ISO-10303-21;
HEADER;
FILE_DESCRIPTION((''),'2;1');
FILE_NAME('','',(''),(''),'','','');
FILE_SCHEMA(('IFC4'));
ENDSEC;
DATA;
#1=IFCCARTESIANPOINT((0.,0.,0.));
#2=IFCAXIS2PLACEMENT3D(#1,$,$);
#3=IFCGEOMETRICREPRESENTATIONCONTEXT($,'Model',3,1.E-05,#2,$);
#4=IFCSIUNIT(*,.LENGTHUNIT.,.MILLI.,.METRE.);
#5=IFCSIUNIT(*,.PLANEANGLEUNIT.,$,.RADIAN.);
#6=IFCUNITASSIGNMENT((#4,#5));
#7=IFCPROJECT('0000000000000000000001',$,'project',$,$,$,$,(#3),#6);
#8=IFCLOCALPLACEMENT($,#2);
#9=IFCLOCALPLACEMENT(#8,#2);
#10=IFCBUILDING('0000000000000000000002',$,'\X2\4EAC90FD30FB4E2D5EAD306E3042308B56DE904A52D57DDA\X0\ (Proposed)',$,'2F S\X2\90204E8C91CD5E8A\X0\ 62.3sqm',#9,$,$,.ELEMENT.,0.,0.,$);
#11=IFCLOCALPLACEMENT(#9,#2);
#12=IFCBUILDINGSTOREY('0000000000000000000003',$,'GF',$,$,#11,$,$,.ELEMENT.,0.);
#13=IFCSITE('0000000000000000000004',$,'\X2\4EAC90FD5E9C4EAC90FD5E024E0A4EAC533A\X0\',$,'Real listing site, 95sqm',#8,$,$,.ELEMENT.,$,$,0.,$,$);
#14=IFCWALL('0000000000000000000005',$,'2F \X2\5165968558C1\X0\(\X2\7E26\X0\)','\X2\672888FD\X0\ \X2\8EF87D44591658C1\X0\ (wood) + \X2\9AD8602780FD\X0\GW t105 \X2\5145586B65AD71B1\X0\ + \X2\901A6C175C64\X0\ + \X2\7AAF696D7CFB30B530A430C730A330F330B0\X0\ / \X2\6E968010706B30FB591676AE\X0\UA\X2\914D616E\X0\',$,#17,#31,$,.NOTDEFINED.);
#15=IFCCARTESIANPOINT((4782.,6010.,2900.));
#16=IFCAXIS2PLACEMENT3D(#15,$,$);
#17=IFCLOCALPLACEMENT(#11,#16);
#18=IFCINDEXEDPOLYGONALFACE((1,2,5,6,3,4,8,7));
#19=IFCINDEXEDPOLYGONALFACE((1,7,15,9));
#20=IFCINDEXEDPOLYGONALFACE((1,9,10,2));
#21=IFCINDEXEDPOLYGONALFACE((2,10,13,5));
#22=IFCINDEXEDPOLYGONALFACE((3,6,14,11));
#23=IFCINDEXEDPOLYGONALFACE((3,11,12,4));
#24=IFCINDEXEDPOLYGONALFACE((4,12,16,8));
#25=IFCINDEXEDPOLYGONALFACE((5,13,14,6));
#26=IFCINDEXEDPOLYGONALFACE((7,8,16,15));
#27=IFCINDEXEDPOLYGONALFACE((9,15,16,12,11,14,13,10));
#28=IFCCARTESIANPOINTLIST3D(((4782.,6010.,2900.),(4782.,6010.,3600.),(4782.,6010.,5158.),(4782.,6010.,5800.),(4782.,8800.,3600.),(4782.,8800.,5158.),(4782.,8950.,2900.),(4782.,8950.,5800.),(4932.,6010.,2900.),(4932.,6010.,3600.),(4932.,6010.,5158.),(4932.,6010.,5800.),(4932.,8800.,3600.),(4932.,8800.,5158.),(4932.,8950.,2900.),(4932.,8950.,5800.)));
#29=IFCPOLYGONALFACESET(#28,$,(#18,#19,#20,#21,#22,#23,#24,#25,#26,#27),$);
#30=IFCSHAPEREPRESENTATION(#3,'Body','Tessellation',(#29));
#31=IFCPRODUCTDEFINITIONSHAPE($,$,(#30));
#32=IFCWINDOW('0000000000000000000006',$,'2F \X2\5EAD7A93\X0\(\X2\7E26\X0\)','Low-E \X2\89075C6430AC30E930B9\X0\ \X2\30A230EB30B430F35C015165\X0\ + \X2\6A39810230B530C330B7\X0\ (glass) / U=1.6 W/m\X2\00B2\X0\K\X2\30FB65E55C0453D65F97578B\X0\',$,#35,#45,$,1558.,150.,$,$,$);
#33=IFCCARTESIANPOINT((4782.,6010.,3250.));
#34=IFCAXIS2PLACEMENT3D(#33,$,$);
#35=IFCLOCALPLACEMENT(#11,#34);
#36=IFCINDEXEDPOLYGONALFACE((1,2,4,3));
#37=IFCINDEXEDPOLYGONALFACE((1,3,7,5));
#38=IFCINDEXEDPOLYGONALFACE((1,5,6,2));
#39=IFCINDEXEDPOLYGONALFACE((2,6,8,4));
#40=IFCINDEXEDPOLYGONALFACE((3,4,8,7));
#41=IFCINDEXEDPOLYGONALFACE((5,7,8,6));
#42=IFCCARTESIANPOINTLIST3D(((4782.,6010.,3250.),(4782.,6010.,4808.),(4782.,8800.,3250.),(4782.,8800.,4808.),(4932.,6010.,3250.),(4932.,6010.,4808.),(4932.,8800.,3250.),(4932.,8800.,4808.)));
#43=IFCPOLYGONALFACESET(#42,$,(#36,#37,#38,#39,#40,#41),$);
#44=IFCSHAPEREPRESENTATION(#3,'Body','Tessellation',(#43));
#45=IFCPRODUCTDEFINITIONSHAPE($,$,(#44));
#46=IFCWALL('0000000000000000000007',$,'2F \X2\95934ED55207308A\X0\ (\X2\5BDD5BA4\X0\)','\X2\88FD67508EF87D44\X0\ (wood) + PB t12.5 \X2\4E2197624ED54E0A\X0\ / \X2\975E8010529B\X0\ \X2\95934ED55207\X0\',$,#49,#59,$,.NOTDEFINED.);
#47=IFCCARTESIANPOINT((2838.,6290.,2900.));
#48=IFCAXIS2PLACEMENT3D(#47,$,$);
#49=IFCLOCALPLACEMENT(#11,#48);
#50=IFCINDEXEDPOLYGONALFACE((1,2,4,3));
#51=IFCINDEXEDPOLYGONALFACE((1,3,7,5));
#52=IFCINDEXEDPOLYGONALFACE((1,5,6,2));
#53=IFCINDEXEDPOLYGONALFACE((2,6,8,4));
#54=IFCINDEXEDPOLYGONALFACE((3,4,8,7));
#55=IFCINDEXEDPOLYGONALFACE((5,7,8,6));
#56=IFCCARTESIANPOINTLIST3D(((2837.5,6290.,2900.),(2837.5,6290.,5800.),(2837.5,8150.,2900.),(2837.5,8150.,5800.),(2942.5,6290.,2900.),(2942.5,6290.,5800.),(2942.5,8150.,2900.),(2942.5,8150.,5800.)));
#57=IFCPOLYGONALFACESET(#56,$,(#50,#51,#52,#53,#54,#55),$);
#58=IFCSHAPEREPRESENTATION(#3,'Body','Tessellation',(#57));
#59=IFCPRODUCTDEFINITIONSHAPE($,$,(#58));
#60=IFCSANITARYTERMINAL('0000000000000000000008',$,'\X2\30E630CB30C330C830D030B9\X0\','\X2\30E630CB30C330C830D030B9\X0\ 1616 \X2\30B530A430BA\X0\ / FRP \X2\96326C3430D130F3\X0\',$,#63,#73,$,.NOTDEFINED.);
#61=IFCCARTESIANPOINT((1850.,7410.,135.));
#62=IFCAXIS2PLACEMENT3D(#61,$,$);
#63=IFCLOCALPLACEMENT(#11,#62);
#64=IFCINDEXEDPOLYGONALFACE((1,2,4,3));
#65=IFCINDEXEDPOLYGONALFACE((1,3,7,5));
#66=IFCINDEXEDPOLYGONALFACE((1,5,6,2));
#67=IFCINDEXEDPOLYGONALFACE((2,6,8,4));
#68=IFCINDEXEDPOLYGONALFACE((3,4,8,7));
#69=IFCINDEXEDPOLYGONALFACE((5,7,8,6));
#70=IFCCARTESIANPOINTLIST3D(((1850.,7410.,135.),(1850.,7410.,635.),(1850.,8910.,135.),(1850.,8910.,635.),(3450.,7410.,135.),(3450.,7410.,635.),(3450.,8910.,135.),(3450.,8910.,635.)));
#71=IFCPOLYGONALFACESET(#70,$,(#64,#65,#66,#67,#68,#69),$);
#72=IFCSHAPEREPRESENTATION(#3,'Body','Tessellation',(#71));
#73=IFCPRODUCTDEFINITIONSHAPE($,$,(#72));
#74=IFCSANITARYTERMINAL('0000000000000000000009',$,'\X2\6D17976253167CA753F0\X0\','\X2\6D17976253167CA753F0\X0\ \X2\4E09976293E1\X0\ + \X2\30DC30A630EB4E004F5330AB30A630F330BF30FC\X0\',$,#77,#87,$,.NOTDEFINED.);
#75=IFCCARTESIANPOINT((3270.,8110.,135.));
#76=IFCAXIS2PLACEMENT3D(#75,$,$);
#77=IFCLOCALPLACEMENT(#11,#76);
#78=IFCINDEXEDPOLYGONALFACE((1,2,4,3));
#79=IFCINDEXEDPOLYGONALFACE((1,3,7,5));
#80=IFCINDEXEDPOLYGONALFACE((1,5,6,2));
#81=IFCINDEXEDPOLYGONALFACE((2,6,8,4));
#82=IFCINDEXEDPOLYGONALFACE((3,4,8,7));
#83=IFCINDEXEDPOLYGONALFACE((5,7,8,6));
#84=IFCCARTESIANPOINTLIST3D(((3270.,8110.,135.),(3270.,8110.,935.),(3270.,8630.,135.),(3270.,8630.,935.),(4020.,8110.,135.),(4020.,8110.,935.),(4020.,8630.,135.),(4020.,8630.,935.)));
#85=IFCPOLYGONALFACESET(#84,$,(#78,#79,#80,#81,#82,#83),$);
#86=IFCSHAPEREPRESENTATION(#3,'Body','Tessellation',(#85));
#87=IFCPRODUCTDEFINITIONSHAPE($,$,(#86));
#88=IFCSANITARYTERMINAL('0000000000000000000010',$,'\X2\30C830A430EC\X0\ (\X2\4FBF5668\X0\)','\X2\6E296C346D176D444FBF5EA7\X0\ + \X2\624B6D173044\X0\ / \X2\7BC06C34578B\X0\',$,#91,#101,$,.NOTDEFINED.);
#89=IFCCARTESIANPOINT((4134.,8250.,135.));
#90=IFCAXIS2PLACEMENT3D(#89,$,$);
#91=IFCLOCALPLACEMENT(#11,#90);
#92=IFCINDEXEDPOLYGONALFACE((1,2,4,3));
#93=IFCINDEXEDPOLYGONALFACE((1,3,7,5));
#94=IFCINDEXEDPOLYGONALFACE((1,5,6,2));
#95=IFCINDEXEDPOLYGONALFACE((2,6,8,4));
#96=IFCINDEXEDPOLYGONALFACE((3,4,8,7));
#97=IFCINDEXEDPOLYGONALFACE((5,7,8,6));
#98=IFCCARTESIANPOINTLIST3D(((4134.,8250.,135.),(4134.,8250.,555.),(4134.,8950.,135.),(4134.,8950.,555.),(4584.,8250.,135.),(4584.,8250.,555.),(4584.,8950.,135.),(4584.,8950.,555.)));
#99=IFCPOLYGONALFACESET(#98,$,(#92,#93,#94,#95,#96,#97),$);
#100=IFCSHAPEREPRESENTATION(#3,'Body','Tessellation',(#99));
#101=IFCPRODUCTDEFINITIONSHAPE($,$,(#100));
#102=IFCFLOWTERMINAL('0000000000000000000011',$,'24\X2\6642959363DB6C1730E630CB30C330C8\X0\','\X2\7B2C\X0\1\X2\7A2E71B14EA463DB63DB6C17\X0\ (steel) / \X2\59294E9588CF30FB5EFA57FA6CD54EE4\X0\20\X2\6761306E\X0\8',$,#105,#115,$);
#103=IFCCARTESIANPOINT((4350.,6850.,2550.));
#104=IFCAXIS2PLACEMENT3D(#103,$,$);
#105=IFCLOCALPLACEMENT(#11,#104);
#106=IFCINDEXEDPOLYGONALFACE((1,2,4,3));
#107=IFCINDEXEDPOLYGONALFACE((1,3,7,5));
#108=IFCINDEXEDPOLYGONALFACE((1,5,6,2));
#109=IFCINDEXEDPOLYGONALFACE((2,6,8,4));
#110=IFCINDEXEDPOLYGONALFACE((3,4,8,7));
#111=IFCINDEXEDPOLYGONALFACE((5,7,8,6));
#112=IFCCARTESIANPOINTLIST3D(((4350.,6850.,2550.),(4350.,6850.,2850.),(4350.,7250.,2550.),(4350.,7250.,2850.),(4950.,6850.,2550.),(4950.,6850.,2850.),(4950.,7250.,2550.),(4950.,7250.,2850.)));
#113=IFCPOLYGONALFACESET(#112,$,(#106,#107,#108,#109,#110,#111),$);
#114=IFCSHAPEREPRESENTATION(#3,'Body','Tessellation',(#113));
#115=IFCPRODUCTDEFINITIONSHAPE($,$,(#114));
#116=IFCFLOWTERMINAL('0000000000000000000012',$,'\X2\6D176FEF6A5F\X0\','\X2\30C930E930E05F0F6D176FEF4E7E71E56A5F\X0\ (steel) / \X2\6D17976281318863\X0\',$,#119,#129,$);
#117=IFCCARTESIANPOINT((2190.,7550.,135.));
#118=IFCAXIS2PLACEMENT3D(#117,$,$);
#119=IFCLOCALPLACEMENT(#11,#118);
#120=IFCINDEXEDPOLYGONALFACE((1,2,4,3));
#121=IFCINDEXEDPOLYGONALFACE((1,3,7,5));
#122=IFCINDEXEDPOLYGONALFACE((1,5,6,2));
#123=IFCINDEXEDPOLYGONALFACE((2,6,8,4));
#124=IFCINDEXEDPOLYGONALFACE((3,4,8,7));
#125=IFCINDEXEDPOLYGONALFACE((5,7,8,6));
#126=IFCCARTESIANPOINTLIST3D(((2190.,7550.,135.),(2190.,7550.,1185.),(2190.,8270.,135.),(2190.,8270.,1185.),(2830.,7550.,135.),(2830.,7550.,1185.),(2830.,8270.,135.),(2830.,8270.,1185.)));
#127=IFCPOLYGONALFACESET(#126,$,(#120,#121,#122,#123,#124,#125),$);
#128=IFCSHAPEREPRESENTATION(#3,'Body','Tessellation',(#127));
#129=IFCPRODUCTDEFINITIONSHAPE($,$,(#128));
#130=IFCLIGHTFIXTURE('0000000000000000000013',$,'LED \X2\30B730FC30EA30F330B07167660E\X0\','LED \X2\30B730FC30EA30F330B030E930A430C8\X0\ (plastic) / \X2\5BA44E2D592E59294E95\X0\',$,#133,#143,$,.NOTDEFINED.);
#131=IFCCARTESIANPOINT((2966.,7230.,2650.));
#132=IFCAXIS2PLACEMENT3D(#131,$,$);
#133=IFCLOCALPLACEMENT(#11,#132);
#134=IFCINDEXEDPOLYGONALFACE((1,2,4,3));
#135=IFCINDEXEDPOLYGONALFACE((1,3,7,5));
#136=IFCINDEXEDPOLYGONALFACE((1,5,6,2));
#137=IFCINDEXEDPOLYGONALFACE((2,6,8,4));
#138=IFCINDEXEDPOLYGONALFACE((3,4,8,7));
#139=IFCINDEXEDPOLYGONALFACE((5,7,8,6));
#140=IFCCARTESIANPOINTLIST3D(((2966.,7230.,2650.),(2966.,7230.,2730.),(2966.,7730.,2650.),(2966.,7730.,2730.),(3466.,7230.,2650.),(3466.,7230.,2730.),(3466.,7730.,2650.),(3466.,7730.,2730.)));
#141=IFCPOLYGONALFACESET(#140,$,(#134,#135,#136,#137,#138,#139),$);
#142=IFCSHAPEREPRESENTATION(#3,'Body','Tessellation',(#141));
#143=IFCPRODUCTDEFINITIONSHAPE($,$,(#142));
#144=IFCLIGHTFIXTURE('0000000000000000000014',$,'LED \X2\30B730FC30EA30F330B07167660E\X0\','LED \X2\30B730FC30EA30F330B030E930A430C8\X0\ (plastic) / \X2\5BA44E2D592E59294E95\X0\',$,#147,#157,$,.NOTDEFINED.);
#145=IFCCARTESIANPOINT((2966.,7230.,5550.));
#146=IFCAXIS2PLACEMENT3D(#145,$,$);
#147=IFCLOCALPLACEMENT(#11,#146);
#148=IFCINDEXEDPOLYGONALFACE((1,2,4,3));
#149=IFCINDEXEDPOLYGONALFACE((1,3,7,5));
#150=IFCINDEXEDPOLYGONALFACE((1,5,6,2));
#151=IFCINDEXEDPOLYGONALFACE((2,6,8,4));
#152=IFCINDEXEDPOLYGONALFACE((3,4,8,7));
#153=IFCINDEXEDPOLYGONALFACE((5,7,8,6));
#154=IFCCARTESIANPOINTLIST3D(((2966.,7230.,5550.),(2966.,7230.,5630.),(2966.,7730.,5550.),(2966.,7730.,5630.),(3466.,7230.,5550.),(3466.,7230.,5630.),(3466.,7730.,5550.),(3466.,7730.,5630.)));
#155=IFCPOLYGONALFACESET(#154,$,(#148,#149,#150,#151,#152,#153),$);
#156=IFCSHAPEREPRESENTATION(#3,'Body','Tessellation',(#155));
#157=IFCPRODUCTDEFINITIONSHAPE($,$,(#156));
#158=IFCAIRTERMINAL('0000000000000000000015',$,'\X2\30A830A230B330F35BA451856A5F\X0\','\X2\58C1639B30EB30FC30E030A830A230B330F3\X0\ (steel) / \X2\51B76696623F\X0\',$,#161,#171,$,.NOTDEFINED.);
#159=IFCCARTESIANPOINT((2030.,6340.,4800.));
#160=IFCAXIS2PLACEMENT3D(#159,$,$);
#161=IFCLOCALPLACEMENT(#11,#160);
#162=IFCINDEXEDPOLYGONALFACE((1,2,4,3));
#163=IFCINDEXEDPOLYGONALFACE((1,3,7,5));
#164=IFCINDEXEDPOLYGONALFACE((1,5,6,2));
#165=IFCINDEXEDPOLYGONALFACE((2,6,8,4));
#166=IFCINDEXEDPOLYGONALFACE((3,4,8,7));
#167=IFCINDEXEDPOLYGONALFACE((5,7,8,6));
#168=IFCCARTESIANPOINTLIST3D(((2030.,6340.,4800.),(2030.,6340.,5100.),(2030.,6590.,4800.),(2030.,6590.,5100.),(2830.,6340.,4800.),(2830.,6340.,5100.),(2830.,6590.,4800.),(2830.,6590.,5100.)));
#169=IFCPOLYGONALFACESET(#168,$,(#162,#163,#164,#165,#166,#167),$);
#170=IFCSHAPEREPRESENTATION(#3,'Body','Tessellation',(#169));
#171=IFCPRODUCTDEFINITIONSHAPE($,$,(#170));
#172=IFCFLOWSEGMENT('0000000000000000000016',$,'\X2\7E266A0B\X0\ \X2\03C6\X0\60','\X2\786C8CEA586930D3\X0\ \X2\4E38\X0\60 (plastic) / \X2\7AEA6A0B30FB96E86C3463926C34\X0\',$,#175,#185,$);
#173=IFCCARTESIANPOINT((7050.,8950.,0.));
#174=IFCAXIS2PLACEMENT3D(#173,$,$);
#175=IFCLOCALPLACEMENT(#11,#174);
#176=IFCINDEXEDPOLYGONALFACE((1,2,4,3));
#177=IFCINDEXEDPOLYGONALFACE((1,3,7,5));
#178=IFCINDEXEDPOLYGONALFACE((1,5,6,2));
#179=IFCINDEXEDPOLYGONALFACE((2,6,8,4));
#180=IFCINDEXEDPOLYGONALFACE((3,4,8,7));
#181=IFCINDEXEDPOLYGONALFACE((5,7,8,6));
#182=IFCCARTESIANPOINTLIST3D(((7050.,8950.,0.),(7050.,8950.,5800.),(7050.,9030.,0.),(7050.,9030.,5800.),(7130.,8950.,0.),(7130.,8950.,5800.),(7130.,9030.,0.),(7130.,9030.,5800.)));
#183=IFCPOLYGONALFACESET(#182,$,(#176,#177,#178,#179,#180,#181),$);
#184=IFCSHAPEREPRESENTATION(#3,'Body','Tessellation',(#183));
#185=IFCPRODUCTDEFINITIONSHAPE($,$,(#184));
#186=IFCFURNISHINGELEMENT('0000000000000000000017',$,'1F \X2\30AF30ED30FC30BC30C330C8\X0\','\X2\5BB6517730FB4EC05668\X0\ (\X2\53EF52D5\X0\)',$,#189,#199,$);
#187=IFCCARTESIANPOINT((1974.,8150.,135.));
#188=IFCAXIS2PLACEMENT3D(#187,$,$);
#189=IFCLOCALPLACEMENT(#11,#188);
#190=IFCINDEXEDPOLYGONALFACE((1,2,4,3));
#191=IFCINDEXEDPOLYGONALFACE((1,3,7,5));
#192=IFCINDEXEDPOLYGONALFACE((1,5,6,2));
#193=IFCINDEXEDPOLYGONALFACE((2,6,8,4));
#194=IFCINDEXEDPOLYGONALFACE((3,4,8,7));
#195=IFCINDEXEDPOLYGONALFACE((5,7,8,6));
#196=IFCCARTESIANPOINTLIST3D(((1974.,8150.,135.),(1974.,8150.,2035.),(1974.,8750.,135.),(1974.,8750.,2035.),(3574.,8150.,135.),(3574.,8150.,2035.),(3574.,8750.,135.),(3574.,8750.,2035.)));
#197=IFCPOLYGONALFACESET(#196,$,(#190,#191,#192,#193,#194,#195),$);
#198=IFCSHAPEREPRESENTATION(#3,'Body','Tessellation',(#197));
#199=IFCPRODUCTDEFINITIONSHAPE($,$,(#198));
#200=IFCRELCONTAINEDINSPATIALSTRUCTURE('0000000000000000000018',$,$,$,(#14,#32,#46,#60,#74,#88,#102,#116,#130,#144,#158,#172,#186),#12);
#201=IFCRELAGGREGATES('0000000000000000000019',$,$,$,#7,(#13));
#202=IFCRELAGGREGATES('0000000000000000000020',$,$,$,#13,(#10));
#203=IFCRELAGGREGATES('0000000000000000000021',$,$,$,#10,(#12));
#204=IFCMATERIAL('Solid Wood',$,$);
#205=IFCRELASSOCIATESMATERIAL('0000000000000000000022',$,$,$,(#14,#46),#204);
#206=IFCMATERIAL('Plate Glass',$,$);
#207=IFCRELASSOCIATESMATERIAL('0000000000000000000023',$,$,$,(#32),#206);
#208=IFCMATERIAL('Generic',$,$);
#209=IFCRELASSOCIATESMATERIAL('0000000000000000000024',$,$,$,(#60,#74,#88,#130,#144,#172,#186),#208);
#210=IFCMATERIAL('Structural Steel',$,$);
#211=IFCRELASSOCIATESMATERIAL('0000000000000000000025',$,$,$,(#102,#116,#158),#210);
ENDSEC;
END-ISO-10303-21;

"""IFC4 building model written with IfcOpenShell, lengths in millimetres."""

from ifc_helpers import new_model, si_unit, frame, frame_2d, origin, place, context, project, spatial, rectangle, extrude, material, element, fill, save


model = new_model("IFC4")

# Units and contexts
model_context = context("Model", 3, precision=1e-05, world=origin())
ifc_project = project(units=[si_unit("LENGTHUNIT", "METRE", prefix="MILLI"), si_unit("PLANEANGLEUNIT", "RADIAN")], contexts=[model_context])

# Site, building, storey
site_placement = place(None, origin())
site = spatial("IfcSite", under=ifc_project, at=site_placement, Name="京都府京都市上京区", ObjectType="Real listing site, 95sqm", CompositionType="ELEMENT", RefElevation=0.0)
building_placement = place(site_placement, origin())
building = spatial("IfcBuilding", under=site, at=building_placement, Name="京都・中庭のある回遊動線 (Proposed)", ObjectType="2F S造二重床 62.3sqm", CompositionType="ELEMENT", ElevationOfRefHeight=0.0, ElevationOfTerrain=0.0)
storey_placement = place(building_placement, origin())
storey = spatial("IfcBuildingStorey", under=building, at=storey_placement, Name="GF", CompositionType="ELEMENT", Elevation=0.0)

# Shared definitions
ifc_material_1 = material(Name="Solid Wood")

# Shared definitions
ifc_material_2 = material(Name="Plate Glass")

# Wall, opening, window
wall_1_placement = place(storey_placement, frame((4782.0, 6010.0, 2900.0)))
wall_1 = element("IfcWall", 1, at=wall_1_placement, inside=storey, material=ifc_material_1, Name="2F 入隅壁(縦)", Description="木製 軸組外壁 (wood) + 高性能GW t105 充填断熱 + 通気層 + 窯業系サイディング / 準耐火・外皮UA配慮", PredefinedType="NOTDEFINED", context=model_context, shape_type="SweptSolid", body=[
    extrude(rectangle(XDim=150.0, YDim=2940.0, at=frame_2d((75.0, 1470.0))), frame((4782.0, 6010.0, 2900.0)), (0.0, 0.0, 1.0), 2900.0),
])
opening_1_placement = place(storey_placement, frame((4782.0, 6010.0, 3250.0)))
opening_1 = element("IfcOpeningElement", 2, at=opening_1_placement, cuts=wall_1, PredefinedType="NOTDEFINED", context=model_context, shape_type="SweptSolid", body=[
    extrude(rectangle(XDim=150.0, YDim=2790.0, at=frame_2d((75.0, 1395.0))), frame((4782.0, 6010.0, 3250.0)), (0.0, 0.0, 1.0), 1558.0),
])
window_1_placement = place(storey_placement, frame((4782.0, 6010.0, 3250.0)))
window_1 = element("IfcWindow", 3, at=window_1_placement, inside=storey, material=ifc_material_2, Name="2F 庭窓(縦)", Description="Low-E 複層ガラス アルゴン封入 + 樹脂サッシ (glass) / U=1.6 W/m²K・日射取得型", OverallHeight=1558.0, OverallWidth=150.0, context=model_context, shape_type="SweptSolid", body=[
    extrude(rectangle(XDim=150.0, YDim=2790.0, at=frame_2d((75.0, 1395.0))), frame((4782.0, 6010.0, 3250.0)), (0.0, 0.0, 1.0), 1558.0),
])
fill(opening_1, window_1)

# Wall
wall_2_placement = place(storey_placement, frame((2838.0, 6290.0, 2900.0)))
element("IfcWall", 4, at=wall_2_placement, inside=storey, material=ifc_material_1, Name="2F 間仕切り (寝室)", Description="製材軸組 (wood) + PB t12.5 両面仕上 / 非耐力 間仕切", PredefinedType="NOTDEFINED", context=model_context, shape_type="SweptSolid", body=[
    extrude(rectangle(XDim=105.0, YDim=1860.0, at=frame_2d((52.0, 930.0))), frame((2838.0, 6290.0, 2900.0)), (0.0, 0.0, 1.0), 2900.0),
])

# Sanitary terminals
ifc_material_3 = material(Name="Generic")
sanitary_terminal_1_placement = place(storey_placement, frame((1850.0, 7410.0, 135.0)))
element("IfcSanitaryTerminal", 5, at=sanitary_terminal_1_placement, inside=storey, material=ifc_material_3, Name="ユニットバス", Description="ユニットバス 1616 サイズ / FRP 防水パン", PredefinedType="NOTDEFINED", context=model_context, shape_type="SweptSolid", body=[
    extrude(rectangle(XDim=1600.0, YDim=1500.0, at=frame_2d((800.0, 750.0))), frame((1850.0, 7410.0, 135.0)), (0.0, 0.0, 1.0), 500.0),
])
sanitary_terminal_2_placement = place(storey_placement, frame((3270.0, 8110.0, 135.0)))
element("IfcSanitaryTerminal", 6, at=sanitary_terminal_2_placement, inside=storey, material=ifc_material_3, Name="洗面化粧台", Description="洗面化粧台 三面鏡 + ボウル一体カウンター", PredefinedType="NOTDEFINED", context=model_context, shape_type="SweptSolid", body=[
    extrude(rectangle(XDim=750.0, YDim=520.0, at=frame_2d((375.0, 260.0))), frame((3270.0, 8110.0, 135.0)), (0.0, 0.0, 1.0), 800.0),
])
sanitary_terminal_3_placement = place(storey_placement, frame((4134.0, 8250.0, 135.0)))
element("IfcSanitaryTerminal", 7, at=sanitary_terminal_3_placement, inside=storey, material=ifc_material_3, Name="トイレ (便器)", Description="温水洗浄便座 + 手洗い / 節水型", PredefinedType="NOTDEFINED", context=model_context, shape_type="SweptSolid", body=[
    extrude(rectangle(XDim=450.0, YDim=700.0, at=frame_2d((225.0, 350.0))), frame((4134.0, 8250.0, 135.0)), (0.0, 0.0, 1.0), 420.0),
])

# Flow terminals
ifc_material_4 = material(Name="Structural Steel")
flow_terminal_1_placement = place(storey_placement, frame((4350.0, 6850.0, 2550.0)))
element("IfcFlowTerminal", 8, at=flow_terminal_1_placement, inside=storey, material=ifc_material_4, Name="24時間換気ユニット", Description="第1種熱交換換気 (steel) / 天井裏・建基法令20条の8", context=model_context, shape_type="SweptSolid", body=[
    extrude(rectangle(XDim=600.0, YDim=400.0, at=frame_2d((300.0, 200.0))), frame((4350.0, 6850.0, 2550.0)), (0.0, 0.0, 1.0), 300.0),
])
flow_terminal_2_placement = place(storey_placement, frame((2190.0, 7550.0, 135.0)))
element("IfcFlowTerminal", 9, at=flow_terminal_2_placement, inside=storey, material=ifc_material_4, Name="洗濯機", Description="ドラム式洗濯乾燥機 (steel) / 洗面脱衣", context=model_context, shape_type="SweptSolid", body=[
    extrude(rectangle(XDim=640.0, YDim=720.0, at=frame_2d((320.0, 360.0))), frame((2190.0, 7550.0, 135.0)), (0.0, 0.0, 1.0), 1050.0),
])

# Light fixtures
light_fixture_1_placement = place(storey_placement, frame((2966.0, 7230.0, 2650.0)))
element("IfcLightFixture", 10, at=light_fixture_1_placement, inside=storey, material=ifc_material_3, Name="LED シーリング照明", Description="LED シーリングライト (plastic) / 室中央天井", PredefinedType="NOTDEFINED", context=model_context, shape_type="SweptSolid", body=[
    extrude(rectangle(XDim=500.0, YDim=500.0, at=frame_2d((250.0, 250.0))), frame((2966.0, 7230.0, 2650.0)), (0.0, 0.0, 1.0), 80.0),
])
light_fixture_2_placement = place(storey_placement, frame((2966.0, 7230.0, 5550.0)))
element("IfcLightFixture", 11, at=light_fixture_2_placement, inside=storey, material=ifc_material_3, Name="LED シーリング照明", Description="LED シーリングライト (plastic) / 室中央天井", PredefinedType="NOTDEFINED", context=model_context, shape_type="SweptSolid", body=[
    extrude(rectangle(XDim=500.0, YDim=500.0, at=frame_2d((250.0, 250.0))), frame((2966.0, 7230.0, 5550.0)), (0.0, 0.0, 1.0), 80.0),
])

# Air terminal
air_terminal_placement = place(storey_placement, frame((2030.0, 6340.0, 4800.0)))
element("IfcAirTerminal", 12, at=air_terminal_placement, inside=storey, material=ifc_material_4, Name="エアコン室内機", Description="壁掛ルームエアコン (steel) / 冷暖房", PredefinedType="NOTDEFINED", context=model_context, shape_type="SweptSolid", body=[
    extrude(rectangle(XDim=800.0, YDim=250.0, at=frame_2d((400.0, 125.0))), frame((2030.0, 6340.0, 4800.0)), (0.0, 0.0, 1.0), 300.0),
])

# Flow segment
flow_segment_placement = place(storey_placement, frame((7050.0, 8950.0, 0.0)))
element("IfcFlowSegment", 13, at=flow_segment_placement, inside=storey, material=ifc_material_3, Name="縦樋 φ60", Description="硬質塩ビ 丸60 (plastic) / 竪樋・雨水排水", context=model_context, shape_type="SweptSolid", body=[
    extrude(rectangle(XDim=80.0, YDim=80.0, at=frame_2d((40.0, 40.0))), frame((7050.0, 8950.0, 0.0)), (0.0, 0.0, 1.0), 5800.0),
])

# Furnishing element
furnishing_1_placement = place(storey_placement, frame((1974.0, 8150.0, 135.0)))
element("IfcFurnishingElement", 14, at=furnishing_1_placement, inside=storey, material=ifc_material_3, Name="1F クローゼット", Description="家具・什器 (可動)", context=model_context, shape_type="SweptSolid", body=[
    extrude(rectangle(XDim=1600.0, YDim=600.0, at=frame_2d((800.0, 300.0))), frame((1974.0, 8150.0, 135.0)), (0.0, 0.0, 1.0), 1900.0),
])

save(model, "model.ifc")
